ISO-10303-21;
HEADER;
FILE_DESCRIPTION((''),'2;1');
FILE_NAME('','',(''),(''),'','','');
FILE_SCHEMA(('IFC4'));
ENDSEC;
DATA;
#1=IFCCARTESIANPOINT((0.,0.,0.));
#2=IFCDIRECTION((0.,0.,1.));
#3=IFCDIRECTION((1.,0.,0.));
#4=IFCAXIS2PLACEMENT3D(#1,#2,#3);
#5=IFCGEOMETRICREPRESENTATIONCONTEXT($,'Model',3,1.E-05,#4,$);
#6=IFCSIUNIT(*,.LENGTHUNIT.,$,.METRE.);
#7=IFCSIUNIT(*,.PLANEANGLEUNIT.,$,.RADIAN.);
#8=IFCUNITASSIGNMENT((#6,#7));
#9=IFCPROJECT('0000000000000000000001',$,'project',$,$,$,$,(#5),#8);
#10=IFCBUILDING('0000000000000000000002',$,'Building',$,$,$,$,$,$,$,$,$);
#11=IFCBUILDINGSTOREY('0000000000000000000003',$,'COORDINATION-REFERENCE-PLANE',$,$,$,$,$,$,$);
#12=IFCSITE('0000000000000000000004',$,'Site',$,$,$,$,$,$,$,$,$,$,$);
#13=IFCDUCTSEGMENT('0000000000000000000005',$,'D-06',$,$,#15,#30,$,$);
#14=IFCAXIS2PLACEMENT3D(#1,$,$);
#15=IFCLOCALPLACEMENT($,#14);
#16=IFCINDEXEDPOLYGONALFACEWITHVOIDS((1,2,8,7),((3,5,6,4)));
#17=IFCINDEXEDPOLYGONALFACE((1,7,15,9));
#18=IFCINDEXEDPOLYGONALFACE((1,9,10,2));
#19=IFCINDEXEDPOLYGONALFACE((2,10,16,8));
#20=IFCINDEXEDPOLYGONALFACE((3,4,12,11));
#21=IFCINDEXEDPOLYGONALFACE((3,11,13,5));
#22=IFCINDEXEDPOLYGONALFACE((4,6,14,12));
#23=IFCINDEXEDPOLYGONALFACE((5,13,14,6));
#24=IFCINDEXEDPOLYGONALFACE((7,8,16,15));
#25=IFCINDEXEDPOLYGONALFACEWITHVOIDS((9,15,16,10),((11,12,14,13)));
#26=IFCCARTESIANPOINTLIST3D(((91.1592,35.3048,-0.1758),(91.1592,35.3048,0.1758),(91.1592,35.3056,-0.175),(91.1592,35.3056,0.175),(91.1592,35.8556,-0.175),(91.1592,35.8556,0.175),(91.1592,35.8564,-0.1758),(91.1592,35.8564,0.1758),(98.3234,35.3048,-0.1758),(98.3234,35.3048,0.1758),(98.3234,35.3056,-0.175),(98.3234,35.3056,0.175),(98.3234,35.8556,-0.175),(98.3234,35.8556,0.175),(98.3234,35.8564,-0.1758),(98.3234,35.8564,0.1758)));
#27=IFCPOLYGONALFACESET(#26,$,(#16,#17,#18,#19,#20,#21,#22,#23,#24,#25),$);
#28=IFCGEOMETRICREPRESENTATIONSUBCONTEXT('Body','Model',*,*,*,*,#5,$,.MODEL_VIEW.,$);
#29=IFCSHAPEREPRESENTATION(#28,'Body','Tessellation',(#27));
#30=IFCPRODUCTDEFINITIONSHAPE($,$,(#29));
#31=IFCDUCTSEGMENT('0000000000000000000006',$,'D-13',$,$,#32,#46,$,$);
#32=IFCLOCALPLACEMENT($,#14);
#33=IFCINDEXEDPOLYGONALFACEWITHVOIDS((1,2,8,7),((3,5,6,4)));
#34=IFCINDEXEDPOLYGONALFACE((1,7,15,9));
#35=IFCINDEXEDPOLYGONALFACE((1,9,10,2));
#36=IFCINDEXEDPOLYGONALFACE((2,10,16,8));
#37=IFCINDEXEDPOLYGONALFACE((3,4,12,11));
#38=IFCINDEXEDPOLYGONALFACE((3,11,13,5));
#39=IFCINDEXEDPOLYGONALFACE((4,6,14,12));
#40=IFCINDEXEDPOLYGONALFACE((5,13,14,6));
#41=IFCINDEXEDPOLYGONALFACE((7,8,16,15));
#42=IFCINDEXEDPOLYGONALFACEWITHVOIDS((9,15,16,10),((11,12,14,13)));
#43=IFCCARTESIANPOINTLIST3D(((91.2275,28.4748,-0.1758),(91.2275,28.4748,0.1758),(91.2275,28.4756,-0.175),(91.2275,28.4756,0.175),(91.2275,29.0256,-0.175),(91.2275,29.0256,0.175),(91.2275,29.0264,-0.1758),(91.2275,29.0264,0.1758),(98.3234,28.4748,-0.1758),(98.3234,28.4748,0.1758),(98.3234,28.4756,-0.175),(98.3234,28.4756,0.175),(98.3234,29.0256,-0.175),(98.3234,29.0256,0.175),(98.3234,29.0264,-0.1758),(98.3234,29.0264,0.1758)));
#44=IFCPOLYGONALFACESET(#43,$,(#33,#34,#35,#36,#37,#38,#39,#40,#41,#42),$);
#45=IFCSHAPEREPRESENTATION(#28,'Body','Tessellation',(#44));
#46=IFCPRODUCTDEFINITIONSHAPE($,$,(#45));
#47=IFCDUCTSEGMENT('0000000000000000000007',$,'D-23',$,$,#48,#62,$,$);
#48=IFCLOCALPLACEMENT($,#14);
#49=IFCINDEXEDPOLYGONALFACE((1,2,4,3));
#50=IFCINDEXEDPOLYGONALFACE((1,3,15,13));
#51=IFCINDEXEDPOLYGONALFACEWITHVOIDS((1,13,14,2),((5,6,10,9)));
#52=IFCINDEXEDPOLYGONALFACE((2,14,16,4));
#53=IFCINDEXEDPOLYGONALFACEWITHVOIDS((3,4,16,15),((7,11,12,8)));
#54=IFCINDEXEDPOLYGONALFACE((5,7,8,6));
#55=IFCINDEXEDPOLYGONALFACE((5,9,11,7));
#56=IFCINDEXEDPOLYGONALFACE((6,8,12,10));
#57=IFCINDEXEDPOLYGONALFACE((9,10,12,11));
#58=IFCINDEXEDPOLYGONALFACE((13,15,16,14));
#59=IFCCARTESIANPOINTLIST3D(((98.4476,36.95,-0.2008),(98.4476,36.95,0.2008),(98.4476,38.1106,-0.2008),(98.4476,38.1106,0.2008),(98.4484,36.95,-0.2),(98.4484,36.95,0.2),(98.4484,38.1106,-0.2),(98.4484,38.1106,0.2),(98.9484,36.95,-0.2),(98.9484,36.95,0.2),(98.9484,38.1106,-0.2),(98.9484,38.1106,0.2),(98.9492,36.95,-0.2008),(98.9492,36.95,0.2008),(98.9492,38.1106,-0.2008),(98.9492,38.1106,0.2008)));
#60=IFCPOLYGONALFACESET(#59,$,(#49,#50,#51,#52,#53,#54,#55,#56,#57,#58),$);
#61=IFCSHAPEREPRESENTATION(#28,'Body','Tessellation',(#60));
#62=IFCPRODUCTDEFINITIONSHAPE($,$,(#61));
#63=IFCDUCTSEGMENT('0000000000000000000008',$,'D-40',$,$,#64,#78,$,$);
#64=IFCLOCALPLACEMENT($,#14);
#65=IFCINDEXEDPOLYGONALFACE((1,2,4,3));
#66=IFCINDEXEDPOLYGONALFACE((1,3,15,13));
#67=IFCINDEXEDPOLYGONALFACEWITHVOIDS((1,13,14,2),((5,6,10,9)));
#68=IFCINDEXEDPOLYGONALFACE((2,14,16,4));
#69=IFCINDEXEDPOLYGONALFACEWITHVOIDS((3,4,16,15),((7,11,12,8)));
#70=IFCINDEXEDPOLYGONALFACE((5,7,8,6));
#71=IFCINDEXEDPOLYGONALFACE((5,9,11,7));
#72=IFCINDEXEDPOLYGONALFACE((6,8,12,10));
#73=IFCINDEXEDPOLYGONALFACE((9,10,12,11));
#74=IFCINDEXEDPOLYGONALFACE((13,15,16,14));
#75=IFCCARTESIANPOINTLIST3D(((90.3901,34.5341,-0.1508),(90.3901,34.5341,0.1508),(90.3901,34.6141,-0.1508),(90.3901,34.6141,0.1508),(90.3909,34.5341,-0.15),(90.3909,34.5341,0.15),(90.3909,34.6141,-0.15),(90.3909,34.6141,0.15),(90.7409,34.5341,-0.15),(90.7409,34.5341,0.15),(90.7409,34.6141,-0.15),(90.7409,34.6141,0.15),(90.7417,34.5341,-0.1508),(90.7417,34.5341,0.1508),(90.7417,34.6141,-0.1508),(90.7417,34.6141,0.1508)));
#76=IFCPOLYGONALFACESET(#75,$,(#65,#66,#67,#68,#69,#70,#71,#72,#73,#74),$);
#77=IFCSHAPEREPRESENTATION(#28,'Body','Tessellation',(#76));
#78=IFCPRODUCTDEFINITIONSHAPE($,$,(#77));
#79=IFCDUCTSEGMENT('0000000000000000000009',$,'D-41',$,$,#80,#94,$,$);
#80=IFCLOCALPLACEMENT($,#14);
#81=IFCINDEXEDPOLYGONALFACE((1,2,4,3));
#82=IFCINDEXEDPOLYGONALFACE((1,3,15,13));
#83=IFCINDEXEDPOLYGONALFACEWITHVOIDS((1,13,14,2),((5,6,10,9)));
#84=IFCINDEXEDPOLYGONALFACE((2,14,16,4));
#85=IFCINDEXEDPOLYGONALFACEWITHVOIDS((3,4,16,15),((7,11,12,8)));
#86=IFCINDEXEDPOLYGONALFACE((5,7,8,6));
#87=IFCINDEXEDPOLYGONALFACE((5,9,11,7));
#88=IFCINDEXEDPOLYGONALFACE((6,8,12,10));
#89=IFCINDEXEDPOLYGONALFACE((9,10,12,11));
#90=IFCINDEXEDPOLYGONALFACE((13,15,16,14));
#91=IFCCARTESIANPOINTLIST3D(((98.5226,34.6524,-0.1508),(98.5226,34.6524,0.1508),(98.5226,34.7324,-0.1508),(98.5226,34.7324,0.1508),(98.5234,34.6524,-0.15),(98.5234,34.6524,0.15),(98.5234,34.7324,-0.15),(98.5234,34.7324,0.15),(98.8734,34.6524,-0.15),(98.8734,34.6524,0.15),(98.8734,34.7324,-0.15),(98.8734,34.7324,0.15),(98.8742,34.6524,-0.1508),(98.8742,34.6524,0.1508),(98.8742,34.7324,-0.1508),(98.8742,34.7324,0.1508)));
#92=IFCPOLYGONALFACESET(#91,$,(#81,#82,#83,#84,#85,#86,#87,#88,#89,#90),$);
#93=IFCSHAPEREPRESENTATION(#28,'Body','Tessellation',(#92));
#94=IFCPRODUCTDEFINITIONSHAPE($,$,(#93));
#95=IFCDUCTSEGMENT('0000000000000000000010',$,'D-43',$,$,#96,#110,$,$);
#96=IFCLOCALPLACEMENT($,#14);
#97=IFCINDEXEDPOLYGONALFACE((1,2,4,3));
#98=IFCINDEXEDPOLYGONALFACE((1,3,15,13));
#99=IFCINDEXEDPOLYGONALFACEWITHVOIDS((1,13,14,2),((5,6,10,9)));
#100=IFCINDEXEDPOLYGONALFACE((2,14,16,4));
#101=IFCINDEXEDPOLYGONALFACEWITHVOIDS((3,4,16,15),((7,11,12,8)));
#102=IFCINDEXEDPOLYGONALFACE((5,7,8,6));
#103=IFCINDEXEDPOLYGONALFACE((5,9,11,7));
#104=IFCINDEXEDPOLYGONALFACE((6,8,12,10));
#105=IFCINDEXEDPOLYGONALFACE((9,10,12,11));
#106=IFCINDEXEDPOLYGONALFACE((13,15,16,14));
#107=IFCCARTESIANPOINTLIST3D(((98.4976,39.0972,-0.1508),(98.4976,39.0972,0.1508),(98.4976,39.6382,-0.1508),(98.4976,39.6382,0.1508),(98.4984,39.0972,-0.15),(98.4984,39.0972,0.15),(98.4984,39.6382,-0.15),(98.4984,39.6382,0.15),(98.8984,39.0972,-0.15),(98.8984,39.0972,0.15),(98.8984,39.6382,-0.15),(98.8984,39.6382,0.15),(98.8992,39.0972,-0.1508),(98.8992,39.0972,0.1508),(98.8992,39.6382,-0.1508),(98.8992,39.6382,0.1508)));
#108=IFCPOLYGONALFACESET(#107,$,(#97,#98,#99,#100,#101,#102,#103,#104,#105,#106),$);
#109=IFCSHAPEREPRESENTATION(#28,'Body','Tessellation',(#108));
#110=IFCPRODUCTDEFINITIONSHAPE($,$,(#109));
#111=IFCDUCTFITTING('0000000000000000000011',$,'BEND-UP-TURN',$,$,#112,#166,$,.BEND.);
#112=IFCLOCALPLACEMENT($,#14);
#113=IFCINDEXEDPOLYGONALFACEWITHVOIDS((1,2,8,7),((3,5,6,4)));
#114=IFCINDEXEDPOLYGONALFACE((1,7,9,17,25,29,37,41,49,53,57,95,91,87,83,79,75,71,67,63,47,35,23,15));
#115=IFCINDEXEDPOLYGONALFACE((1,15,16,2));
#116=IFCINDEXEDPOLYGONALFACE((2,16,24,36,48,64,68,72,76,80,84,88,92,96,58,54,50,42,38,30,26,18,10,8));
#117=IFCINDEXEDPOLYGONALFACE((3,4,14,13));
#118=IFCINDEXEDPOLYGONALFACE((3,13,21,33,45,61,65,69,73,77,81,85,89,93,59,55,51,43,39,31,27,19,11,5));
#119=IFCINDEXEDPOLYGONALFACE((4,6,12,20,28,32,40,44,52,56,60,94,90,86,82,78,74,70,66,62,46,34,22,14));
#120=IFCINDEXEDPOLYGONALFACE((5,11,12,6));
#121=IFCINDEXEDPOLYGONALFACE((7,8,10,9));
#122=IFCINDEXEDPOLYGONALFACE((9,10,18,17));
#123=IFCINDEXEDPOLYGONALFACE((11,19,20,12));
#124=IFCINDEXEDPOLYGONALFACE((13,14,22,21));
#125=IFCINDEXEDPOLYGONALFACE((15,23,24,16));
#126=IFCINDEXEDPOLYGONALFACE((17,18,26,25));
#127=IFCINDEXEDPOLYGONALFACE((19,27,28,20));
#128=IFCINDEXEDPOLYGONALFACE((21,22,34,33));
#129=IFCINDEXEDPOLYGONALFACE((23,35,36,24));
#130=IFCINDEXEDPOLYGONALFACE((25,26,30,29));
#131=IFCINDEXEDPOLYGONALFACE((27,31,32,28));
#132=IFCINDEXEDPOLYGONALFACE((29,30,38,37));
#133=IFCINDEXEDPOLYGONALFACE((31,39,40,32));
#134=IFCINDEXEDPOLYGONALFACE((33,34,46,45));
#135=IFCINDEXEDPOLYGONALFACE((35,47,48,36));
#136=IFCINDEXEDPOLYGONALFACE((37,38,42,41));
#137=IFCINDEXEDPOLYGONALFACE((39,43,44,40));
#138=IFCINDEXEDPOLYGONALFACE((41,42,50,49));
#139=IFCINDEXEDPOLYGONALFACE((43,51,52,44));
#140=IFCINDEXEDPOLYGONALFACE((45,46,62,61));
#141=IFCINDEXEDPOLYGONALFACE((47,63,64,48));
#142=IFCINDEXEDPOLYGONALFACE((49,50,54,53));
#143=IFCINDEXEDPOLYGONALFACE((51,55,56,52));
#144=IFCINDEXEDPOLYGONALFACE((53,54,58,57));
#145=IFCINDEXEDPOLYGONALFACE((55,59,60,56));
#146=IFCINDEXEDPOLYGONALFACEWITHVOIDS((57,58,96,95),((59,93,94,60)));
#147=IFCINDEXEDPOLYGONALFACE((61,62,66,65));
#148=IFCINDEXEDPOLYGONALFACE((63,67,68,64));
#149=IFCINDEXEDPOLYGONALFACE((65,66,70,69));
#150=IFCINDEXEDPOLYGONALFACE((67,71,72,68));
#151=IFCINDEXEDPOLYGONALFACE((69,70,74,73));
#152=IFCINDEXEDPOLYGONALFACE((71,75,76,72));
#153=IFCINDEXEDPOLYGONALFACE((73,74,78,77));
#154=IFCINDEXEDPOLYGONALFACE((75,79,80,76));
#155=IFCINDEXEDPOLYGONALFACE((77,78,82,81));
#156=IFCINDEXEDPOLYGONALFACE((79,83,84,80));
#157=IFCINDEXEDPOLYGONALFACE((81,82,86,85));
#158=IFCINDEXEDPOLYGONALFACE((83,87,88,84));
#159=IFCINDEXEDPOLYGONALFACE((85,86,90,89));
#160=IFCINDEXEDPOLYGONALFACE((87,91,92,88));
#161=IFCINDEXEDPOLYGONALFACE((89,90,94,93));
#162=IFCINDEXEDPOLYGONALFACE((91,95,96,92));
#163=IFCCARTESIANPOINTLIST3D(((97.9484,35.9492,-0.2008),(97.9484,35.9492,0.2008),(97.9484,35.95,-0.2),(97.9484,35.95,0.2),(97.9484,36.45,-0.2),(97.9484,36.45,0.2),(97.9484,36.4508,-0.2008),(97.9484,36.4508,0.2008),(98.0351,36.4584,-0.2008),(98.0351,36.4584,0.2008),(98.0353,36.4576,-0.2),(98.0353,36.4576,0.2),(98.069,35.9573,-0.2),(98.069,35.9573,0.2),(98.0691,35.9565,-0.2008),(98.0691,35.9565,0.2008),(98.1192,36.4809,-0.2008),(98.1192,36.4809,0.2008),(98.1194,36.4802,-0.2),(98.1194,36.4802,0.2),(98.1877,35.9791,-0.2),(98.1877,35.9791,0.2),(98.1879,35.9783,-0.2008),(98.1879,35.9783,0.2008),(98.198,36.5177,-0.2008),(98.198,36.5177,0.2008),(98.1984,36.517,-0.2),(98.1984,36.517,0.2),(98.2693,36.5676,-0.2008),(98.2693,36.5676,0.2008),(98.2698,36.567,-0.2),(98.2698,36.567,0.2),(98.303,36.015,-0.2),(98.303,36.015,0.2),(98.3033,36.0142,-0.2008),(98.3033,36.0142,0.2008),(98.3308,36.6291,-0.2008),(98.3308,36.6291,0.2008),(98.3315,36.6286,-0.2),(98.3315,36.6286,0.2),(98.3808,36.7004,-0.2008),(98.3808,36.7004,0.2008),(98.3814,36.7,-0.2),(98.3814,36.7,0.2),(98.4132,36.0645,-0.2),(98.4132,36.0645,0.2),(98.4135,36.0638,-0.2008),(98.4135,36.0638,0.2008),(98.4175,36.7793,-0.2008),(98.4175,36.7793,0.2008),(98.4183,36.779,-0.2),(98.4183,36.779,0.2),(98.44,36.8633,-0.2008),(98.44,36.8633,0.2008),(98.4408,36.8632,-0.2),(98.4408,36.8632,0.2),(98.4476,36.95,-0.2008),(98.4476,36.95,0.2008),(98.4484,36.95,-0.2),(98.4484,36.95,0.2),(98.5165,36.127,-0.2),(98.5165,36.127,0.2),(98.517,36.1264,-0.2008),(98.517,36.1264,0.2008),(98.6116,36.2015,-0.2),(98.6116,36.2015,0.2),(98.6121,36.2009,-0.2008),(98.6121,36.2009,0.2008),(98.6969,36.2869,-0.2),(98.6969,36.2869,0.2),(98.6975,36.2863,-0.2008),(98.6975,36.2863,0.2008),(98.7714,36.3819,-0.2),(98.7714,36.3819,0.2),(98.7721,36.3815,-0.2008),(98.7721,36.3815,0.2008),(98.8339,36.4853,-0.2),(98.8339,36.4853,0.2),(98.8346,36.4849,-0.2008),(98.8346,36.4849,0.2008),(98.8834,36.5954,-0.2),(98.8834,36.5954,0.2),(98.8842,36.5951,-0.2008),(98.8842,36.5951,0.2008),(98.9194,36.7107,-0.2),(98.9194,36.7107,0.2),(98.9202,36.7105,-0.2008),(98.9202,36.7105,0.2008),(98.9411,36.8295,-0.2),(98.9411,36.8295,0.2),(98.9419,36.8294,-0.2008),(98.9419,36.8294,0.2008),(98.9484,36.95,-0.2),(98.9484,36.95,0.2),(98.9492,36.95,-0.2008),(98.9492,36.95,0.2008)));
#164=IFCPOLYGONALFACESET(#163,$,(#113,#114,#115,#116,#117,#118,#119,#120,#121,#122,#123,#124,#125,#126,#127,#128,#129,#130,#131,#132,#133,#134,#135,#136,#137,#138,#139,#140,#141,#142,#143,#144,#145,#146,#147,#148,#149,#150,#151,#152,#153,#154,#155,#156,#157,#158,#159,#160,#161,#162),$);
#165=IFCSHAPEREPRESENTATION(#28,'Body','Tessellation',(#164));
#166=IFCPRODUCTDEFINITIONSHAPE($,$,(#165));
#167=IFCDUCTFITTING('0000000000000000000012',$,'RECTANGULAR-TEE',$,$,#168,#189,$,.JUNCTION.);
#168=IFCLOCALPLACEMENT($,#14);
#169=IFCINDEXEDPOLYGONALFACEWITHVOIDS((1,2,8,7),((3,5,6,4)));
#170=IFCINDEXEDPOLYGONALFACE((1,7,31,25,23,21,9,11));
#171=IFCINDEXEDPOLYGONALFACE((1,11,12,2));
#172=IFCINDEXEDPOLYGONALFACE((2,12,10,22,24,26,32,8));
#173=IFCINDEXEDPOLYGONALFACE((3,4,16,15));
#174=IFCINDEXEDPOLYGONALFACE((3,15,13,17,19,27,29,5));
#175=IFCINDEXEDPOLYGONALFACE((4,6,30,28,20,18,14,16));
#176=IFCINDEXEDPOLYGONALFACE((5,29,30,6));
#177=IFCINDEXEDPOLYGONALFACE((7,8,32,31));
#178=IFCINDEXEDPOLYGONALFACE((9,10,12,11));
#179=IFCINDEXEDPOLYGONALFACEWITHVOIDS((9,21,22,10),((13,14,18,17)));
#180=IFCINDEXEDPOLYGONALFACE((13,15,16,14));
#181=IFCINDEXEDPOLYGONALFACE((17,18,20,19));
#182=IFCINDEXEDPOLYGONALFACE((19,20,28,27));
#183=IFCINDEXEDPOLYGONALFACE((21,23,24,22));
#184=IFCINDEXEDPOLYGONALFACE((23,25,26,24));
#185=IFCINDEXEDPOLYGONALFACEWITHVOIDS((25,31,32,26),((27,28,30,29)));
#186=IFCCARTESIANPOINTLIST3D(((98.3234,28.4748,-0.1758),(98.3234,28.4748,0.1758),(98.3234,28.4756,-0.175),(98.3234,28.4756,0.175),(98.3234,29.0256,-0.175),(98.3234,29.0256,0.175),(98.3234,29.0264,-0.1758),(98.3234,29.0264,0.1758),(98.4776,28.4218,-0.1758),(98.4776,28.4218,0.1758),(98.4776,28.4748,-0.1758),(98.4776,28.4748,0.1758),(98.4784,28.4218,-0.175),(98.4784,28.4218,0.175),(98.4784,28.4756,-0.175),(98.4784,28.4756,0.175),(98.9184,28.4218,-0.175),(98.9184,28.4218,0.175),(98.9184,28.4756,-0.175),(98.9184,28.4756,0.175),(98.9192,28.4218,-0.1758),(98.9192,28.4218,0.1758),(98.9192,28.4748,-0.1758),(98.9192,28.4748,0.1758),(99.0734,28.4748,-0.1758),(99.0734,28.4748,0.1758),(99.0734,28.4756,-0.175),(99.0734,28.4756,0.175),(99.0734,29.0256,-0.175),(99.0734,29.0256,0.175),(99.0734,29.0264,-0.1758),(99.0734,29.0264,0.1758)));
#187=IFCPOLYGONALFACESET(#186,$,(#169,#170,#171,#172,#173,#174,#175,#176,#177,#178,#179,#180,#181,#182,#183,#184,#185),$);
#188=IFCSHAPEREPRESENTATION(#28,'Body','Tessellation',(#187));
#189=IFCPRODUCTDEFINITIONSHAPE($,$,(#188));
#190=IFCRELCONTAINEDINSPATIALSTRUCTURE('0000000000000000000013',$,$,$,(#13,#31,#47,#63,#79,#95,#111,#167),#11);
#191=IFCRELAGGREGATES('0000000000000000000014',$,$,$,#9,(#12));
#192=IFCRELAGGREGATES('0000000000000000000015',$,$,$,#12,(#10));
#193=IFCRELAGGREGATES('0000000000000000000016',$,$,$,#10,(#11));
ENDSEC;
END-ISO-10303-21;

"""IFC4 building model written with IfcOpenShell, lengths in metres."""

from ifc_helpers import new_model, entity, si_unit, frame, origin, origin_with_axes, place, context, subcontext, project, spatial, rectangle, hollow_rectangle, extrude, boolean, element, save


model = new_model("IFC4")

# Units and contexts
model_context = context("Model", 3, precision=1e-05, world=origin_with_axes())
body_context_1 = subcontext(model_context, "Body", "Model", "MODEL_VIEW")
ifc_project = project(units=[si_unit("LENGTHUNIT", "METRE"), si_unit("PLANEANGLEUNIT", "RADIAN")], contexts=[model_context])

# Site, building, storey
site = spatial("IfcSite", under=ifc_project, Name="Site")
building = spatial("IfcBuilding", under=site, Name="Building")
storey = spatial("IfcBuildingStorey", under=building, Name="COORDINATION-REFERENCE-PLANE")

# Duct segments
duct_segment_1_placement = place(None, frame((91.1592, 35.5806, 0.0), z_axis=(1.0, 0.0, 0.0), x_axis=(0.0, 1.0, 0.0)))
element("IfcDuctSegment", 1, at=duct_segment_1_placement, inside=storey, Name="D-06", context=body_context_1, shape_type="SweptSolid", body=[
    extrude(hollow_rectangle(XDim=0.5516, YDim=0.3516, WallThickness=0.0008), origin(), (0.0, 0.0, 1.0), 7.1642),
])
duct_segment_2_placement = place(None, frame((91.2275, 28.7506, 0.0), z_axis=(1.0, 0.0, 0.0), x_axis=(0.0, 1.0, 0.0)))
element("IfcDuctSegment", 2, at=duct_segment_2_placement, inside=storey, Name="D-13", context=body_context_1, shape_type="SweptSolid", body=[
    extrude(hollow_rectangle(XDim=0.5516, YDim=0.3516, WallThickness=0.0008), origin(), (0.0, 0.0, 1.0), 7.0959),
])
duct_segment_3_placement = place(None, frame((98.6984, 36.95, 0.0), z_axis=(0.0, 1.0, 0.0), x_axis=(1.0, 0.0, 0.0)))
element("IfcDuctSegment", 3, at=duct_segment_3_placement, inside=storey, Name="D-23", context=body_context_1, shape_type="SweptSolid", body=[
    extrude(hollow_rectangle(XDim=0.5016, YDim=0.4016, WallThickness=0.0008), origin(), (0.0, 0.0, 1.0), 1.1606),
])
for number, where, z_axis, x_axis, name in (
    (4, (90.5659, 34.5341, 0.0), (0.0, 1.0, 0.0), (1.0, 0.0, 0.0), "D-40"),
    (5, (98.6984, 34.6524, 0.0), (0.0, 1.0, 0.0), (1.0, 0.0, 0.0), "D-41"),
):
    element("IfcDuctSegment", number, at=place(None, frame(where, z_axis=z_axis, x_axis=x_axis)), inside=storey, Name=name, context=body_context_1, shape_type="SweptSolid", body=[
        extrude(hollow_rectangle(XDim=0.3516, YDim=0.3016, WallThickness=0.0008), origin(), (0.0, 0.0, 1.0), 0.08),
    ])
duct_segment_4_placement = place(None, frame((98.6984, 39.0972, 0.0), z_axis=(0.0, 1.0, 0.0), x_axis=(1.0, 0.0, 0.0)))
element("IfcDuctSegment", 6, at=duct_segment_4_placement, inside=storey, Name="D-43", context=body_context_1, shape_type="SweptSolid", body=[
    extrude(hollow_rectangle(XDim=0.4016, YDim=0.3016, WallThickness=0.0008), origin(), (0.0, 0.0, 1.0), 0.541),
])

# Duct fittings
duct_fitting_1_placement = place(None, frame((97.9484, 36.95, 0.0), z_axis=(0.0, 0.0, 1.0), x_axis=(0.0, -1.0, 0.0)))
cartesian_point = entity("IfcCartesianPoint", [0.0, 0.0, 0.0])
element("IfcDuctFitting", 7, at=duct_fitting_1_placement, inside=storey, Name="BEND-UP-TURN", PredefinedType="BEND", context=body_context_1, shape_type="SweptSolid", body=[
    entity("IfcRevolvedAreaSolid", entity("IfcRectangleHollowProfileDef", "AREA", None, entity("IfcAxis2Placement2D", entity("IfcCartesianPoint", [0.75, 0.0])), 0.5016, 0.4016, 0.0008), entity("IfcAxis2Placement3D", cartesian_point, entity("IfcDirection", [0.0, -1.0, 0.0]), entity("IfcDirection", [1.0, 0.0, 0.0])), entity("IfcAxis1Placement", cartesian_point, entity("IfcDirection", [0.0, 1.0, 0.0])), 1.570796),
])
duct_fitting_2_placement = place(None, frame((98.6984, 28.7506, 0.0), z_axis=(1.0, 0.0, 0.0), x_axis=(0.0, -1.0, 0.0)))
solid_1 = boolean("UNION", extrude(rectangle(XDim=0.55, YDim=0.35), frame((0.0, 0.0, -0.375), z_axis=(0.0, 0.0, 1.0), x_axis=(1.0, 0.0, 0.0)), (0.0, 0.0, 1.0), 0.75), extrude(rectangle(XDim=0.44, YDim=0.35), frame((0.0, 0.0, 0.0), z_axis=(1.0, 0.0, 0.0), x_axis=(0.0, 0.0, -1.0)), (0.0, 0.0, 1.0), 0.3288))
element("IfcDuctFitting", 8, at=duct_fitting_2_placement, inside=storey, Name="RECTANGULAR-TEE", PredefinedType="JUNCTION", context=body_context_1, shape_type="CSG", body=[
    boolean("DIFFERENCE", boolean("UNION", extrude(rectangle(XDim=0.5516, YDim=0.3516), frame((0.0, 0.0, -0.375), z_axis=(0.0, 0.0, 1.0), x_axis=(1.0, 0.0, 0.0)), (0.0, 0.0, 1.0), 0.75), extrude(rectangle(XDim=0.4416, YDim=0.3516), frame((0.0, 0.0, 0.0), z_axis=(1.0, 0.0, 0.0), x_axis=(0.0, 0.0, -1.0)), (0.0, 0.0, 1.0), 0.3288)), solid_1),
])

save(model, "model.ifc")
